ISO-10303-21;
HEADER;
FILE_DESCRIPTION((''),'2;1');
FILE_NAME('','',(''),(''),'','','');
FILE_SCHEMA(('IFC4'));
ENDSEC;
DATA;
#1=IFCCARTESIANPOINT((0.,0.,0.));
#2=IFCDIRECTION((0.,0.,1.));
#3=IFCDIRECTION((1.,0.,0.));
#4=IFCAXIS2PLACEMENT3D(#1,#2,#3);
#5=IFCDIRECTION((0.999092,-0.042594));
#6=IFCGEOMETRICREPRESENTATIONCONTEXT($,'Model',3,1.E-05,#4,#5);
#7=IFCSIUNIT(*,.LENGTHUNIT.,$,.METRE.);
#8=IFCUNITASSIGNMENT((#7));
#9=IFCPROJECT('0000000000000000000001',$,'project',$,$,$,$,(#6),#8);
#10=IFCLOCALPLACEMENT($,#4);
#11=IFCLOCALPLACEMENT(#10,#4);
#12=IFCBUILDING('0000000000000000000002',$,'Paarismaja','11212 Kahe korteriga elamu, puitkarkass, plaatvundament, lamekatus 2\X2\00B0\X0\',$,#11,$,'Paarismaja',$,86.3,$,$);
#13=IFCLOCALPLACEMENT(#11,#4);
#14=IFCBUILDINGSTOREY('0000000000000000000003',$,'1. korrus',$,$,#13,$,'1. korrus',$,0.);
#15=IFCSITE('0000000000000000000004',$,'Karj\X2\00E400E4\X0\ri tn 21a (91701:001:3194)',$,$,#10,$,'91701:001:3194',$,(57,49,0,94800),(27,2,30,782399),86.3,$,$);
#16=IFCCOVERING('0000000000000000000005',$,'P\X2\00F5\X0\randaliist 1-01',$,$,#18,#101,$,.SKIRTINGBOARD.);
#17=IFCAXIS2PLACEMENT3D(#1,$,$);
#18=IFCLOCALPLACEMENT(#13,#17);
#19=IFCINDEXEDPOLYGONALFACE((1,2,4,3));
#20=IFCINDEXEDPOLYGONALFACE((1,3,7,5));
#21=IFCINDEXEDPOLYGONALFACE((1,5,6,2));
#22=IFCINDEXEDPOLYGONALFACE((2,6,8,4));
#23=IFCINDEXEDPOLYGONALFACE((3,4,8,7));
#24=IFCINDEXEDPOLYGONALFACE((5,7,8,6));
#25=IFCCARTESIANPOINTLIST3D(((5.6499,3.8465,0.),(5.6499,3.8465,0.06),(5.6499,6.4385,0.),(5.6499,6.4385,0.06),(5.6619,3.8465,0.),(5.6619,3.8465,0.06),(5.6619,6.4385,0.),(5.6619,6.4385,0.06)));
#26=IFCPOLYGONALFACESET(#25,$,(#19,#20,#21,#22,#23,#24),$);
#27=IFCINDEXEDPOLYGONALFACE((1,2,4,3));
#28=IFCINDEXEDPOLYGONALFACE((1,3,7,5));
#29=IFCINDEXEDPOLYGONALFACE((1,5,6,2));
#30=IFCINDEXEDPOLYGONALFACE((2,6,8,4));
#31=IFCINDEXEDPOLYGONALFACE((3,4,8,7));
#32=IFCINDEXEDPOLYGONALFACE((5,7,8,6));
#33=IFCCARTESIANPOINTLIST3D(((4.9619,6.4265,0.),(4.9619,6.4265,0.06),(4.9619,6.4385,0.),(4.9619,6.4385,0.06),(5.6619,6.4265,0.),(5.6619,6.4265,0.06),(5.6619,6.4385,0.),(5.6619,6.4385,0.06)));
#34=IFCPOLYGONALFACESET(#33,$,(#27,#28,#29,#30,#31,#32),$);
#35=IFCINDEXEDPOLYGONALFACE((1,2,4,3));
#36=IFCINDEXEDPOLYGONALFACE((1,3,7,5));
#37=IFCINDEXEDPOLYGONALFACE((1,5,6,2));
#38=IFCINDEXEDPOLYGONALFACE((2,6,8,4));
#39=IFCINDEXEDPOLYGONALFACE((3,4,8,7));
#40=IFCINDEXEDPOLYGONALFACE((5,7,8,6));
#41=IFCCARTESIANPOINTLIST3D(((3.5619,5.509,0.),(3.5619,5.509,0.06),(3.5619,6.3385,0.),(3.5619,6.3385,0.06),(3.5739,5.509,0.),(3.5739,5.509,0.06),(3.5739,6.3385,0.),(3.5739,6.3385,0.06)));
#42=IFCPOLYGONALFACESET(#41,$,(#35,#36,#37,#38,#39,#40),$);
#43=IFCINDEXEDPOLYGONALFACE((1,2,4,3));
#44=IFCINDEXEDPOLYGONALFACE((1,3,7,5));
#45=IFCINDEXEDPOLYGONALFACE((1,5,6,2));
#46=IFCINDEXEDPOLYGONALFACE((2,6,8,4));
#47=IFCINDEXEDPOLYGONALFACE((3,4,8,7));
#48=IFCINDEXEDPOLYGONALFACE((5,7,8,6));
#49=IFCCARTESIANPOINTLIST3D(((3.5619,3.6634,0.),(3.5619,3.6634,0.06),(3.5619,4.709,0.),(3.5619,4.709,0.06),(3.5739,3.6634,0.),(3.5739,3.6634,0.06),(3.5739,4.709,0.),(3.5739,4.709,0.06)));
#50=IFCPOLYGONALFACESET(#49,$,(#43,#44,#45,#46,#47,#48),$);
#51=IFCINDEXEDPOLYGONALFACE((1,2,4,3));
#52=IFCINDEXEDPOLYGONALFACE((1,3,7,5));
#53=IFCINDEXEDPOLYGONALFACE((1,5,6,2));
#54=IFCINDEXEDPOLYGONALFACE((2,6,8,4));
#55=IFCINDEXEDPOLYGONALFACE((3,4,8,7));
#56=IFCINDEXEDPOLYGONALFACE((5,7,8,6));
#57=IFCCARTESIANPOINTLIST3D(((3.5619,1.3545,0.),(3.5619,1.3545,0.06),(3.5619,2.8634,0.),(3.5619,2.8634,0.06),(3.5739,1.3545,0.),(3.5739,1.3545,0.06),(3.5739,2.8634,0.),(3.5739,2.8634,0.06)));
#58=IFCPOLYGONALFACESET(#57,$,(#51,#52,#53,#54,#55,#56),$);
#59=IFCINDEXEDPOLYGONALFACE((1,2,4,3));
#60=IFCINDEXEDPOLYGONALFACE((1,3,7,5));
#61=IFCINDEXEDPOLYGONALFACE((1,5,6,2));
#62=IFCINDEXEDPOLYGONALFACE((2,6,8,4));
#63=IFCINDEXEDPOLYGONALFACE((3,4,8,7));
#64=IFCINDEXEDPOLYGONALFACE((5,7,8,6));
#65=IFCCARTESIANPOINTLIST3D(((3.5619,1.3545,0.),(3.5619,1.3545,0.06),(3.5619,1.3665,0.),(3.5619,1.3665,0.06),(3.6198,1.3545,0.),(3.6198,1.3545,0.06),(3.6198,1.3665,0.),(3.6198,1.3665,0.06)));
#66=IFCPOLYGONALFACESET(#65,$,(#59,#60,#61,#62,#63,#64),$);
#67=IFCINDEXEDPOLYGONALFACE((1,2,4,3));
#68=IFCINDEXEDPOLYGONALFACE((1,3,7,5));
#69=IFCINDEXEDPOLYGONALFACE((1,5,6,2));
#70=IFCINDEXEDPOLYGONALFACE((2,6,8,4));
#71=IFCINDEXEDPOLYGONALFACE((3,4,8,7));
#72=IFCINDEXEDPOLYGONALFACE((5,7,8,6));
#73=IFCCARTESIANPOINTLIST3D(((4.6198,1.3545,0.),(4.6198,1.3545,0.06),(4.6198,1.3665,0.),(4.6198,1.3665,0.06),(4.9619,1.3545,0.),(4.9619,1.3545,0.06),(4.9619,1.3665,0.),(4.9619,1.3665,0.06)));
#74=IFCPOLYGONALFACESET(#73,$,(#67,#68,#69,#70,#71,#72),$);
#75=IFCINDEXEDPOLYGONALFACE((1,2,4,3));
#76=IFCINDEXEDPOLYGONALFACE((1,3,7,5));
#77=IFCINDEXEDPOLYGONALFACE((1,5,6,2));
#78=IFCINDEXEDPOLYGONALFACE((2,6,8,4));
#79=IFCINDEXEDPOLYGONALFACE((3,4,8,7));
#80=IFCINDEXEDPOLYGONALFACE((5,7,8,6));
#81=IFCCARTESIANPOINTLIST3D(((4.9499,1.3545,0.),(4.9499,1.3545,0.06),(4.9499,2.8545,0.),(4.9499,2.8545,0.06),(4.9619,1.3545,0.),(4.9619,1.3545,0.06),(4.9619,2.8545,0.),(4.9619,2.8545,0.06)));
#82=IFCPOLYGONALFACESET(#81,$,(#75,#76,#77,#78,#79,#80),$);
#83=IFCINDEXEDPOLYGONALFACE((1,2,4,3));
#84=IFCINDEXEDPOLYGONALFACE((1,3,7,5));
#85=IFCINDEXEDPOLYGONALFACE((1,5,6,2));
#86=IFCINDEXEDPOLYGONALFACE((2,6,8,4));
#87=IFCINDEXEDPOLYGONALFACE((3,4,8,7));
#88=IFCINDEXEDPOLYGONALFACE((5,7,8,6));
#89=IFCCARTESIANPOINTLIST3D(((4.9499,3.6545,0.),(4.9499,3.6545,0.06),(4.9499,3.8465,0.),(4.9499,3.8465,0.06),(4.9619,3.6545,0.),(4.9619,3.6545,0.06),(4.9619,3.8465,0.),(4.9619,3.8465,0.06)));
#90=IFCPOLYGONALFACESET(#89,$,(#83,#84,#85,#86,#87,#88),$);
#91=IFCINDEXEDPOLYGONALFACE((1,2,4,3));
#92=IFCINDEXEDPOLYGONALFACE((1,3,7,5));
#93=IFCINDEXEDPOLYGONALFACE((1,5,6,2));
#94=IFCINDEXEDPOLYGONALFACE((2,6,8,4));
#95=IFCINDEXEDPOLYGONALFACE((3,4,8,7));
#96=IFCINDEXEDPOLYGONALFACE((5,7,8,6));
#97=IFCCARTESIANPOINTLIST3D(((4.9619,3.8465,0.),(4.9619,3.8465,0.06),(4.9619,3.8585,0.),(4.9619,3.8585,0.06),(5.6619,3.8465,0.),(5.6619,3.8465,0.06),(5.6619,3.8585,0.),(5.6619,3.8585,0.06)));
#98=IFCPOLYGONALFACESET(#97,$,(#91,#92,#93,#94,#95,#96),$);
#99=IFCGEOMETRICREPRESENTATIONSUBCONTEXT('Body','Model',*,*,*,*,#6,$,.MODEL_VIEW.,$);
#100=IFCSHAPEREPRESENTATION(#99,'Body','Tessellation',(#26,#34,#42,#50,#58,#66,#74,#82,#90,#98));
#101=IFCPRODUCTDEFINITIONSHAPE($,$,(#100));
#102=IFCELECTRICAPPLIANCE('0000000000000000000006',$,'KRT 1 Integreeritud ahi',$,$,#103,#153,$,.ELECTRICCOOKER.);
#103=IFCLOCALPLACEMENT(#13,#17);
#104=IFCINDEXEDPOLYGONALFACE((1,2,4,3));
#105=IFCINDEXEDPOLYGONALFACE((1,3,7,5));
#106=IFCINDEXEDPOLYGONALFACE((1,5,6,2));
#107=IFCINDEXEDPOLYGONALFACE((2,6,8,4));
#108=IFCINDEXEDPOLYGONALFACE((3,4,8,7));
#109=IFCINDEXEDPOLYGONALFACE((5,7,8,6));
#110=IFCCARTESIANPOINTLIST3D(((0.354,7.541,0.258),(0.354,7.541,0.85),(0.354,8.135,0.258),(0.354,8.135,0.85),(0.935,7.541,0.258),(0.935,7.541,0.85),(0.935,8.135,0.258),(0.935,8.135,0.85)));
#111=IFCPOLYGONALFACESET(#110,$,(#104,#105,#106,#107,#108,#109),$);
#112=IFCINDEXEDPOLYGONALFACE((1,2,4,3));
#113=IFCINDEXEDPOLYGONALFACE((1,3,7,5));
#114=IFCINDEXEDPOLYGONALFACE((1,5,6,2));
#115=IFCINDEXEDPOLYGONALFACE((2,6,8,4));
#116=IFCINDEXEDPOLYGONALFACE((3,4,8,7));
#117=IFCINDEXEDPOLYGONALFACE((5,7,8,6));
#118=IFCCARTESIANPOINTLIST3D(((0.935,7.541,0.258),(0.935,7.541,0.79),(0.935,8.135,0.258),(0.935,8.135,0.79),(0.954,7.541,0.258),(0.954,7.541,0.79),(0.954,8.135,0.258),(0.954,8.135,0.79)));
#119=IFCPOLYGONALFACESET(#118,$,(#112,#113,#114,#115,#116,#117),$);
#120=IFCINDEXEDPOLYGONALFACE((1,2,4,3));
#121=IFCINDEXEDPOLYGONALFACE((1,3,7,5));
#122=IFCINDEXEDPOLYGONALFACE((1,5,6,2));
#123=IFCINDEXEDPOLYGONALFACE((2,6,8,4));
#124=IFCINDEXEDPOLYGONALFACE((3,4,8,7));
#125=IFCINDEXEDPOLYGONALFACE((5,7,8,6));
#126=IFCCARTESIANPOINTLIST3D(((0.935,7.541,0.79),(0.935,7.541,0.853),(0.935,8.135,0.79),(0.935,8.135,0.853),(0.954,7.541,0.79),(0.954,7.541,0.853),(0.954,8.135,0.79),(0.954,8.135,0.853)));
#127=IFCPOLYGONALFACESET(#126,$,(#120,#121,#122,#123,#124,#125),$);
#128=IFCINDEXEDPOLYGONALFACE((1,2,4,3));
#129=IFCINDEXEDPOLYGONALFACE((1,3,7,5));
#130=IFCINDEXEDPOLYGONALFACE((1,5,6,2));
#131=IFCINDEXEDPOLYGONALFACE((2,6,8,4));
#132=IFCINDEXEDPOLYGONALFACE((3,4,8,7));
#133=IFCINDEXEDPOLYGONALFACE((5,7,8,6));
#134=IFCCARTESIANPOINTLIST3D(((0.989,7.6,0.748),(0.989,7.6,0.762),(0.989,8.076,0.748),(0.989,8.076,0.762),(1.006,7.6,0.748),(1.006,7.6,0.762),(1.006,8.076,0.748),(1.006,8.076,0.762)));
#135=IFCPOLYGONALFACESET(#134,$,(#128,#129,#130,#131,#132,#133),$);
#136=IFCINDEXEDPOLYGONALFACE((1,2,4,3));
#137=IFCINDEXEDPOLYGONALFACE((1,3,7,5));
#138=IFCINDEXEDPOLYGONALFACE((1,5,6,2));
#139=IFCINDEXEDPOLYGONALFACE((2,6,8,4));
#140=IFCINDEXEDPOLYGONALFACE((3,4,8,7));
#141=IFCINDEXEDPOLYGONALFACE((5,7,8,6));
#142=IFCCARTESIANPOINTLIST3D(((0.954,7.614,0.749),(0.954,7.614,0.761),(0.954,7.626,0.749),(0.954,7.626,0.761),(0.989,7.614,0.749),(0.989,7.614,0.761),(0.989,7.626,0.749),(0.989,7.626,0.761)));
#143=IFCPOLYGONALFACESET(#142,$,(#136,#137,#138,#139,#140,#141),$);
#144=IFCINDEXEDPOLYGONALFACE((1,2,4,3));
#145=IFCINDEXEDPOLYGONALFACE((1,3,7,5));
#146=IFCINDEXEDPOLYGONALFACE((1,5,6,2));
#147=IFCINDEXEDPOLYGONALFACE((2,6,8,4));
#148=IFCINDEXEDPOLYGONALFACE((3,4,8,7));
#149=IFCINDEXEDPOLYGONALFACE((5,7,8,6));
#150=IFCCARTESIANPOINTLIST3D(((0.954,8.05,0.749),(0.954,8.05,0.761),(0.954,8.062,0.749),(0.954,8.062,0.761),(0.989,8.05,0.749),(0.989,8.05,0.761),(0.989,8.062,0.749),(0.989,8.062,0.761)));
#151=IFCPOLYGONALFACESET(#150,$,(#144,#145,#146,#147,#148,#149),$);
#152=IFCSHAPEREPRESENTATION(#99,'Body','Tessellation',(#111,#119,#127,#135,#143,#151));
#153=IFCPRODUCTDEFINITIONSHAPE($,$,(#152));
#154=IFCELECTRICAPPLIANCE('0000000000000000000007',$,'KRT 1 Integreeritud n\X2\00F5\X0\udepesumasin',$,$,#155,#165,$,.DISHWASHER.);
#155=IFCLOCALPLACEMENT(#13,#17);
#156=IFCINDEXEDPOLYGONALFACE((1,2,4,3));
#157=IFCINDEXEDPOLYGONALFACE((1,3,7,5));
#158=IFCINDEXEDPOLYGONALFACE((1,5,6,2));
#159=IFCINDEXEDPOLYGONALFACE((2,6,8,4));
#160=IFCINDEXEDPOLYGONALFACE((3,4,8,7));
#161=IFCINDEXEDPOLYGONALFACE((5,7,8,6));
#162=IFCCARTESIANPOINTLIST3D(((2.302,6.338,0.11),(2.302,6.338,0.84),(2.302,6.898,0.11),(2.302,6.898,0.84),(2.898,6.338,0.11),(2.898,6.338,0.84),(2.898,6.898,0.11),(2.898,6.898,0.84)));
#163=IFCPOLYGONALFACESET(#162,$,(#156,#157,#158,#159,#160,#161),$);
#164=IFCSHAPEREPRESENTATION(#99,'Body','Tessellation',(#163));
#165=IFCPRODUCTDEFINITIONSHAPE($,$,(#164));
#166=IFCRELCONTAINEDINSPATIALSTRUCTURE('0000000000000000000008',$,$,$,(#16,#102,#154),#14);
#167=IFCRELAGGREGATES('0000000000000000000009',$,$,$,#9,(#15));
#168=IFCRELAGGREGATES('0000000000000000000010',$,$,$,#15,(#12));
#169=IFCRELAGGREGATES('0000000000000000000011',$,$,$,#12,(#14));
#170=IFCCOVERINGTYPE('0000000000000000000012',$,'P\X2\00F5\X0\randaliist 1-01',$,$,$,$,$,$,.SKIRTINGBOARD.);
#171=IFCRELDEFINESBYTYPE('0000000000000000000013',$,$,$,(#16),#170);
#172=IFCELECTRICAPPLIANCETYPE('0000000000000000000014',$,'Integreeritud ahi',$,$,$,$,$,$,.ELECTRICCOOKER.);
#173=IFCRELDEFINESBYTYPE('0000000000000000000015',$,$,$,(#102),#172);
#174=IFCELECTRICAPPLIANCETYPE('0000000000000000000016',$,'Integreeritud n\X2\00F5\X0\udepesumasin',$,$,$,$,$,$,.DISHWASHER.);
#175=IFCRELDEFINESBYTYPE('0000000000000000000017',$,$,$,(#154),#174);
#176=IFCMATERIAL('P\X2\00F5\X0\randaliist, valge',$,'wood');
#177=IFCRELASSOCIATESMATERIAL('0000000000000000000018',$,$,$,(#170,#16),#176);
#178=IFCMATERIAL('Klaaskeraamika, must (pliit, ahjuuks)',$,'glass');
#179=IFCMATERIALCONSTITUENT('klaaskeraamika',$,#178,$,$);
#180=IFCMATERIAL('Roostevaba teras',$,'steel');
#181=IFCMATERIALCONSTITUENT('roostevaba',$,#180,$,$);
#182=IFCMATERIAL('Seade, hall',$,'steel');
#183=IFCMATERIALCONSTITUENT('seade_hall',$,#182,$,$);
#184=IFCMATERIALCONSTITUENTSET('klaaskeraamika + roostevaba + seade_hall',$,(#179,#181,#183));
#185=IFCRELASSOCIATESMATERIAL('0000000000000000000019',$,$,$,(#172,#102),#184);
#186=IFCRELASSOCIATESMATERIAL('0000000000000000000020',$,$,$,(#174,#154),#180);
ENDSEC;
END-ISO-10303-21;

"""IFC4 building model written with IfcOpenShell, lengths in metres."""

from ifc_helpers import new_model, si_unit, direction, frame, origin_with_axes, place, context, subcontext, project, spatial, indexed_curve, outline, extrude, material, constituent, constituent_set, type_object, element, save


model = new_model("IFC4")

# Units and contexts
model_context = context("Model", 3, precision=1e-05, world=origin_with_axes(), true_north=direction((0.999092, -0.042594)))
body_context = subcontext(model_context, "Body", "Model", "MODEL_VIEW")
ifc_project = project(units=[si_unit("LENGTHUNIT", "METRE")], contexts=[model_context])

# Site, building, storey
site_placement = place(None, origin_with_axes())
site = spatial("IfcSite", under=ifc_project, at=site_placement, Name="Karjääri tn 21a (91701:001:3194)", LongName="91701:001:3194", RefLatitude=(57, 49, 0, 94800), RefLongitude=(27, 2, 30, 782399), RefElevation=86.3)
building_placement = place(site_placement, origin_with_axes())
building = spatial("IfcBuilding", under=site, at=building_placement, Name="Paarismaja", Description="11212 Kahe korteriga elamu, puitkarkass, plaatvundament, lamekatus 2°", LongName="Paarismaja", ElevationOfRefHeight=86.3)
storey_placement = place(building_placement, origin_with_axes())
storey = spatial("IfcBuildingStorey", under=building, at=storey_placement, Name="1. korrus", LongName="1. korrus", Elevation=0.0)

# Covering
ifc_material_1 = material(Name="Põrandaliist, valge", Category="wood")
covering_type_1 = type_object("IfcCoveringType", Name="Põrandaliist 1-01", PredefinedType="SKIRTINGBOARD", material=ifc_material_1)
covering_1_placement = place(storey_placement, origin_with_axes())
element("IfcCovering", 1, at=covering_1_placement, inside=storey, type_object=covering_type_1, material=ifc_material_1, Name="Põrandaliist 1-01", PredefinedType="SKIRTINGBOARD", context=body_context, shape_type="SweptSolid", body=[
    extrude(outline(indexed_curve([(5.6499, 3.8465), (5.6499, 6.4385), (5.6619, 6.4385), (5.6619, 3.8465), (5.6499, 3.8465)], self_intersect=False)), origin_with_axes(), (0.0, 0.0, 1.0), 0.06),
    extrude(outline(indexed_curve([(5.6619, 6.4265), (4.9619, 6.4265), (4.9619, 6.4385), (5.6619, 6.4385), (5.6619, 6.4265)], self_intersect=False)), origin_with_axes(), (0.0, 0.0, 1.0), 0.06),
    extrude(outline(indexed_curve([(3.5619, 6.3385), (3.5739, 6.3385), (3.5739, 5.509), (3.5619, 5.509), (3.5619, 6.3385)], self_intersect=False)), origin_with_axes(), (0.0, 0.0, 1.0), 0.06),
    extrude(outline(indexed_curve([(3.5619, 4.709), (3.5739, 4.709), (3.5739, 3.6634), (3.5619, 3.6634), (3.5619, 4.709)], self_intersect=False)), origin_with_axes(), (0.0, 0.0, 1.0), 0.06),
    extrude(outline(indexed_curve([(3.5739, 1.3545), (3.5619, 1.3545), (3.5619, 2.8634), (3.5739, 2.8634), (3.5739, 1.3545)], self_intersect=False)), origin_with_axes(), (0.0, 0.0, 1.0), 0.06),
    extrude(outline(indexed_curve([(3.5619, 1.3545), (3.5619, 1.3665), (3.6198, 1.3665), (3.6198, 1.3545), (3.5619, 1.3545)], self_intersect=False)), origin_with_axes(), (0.0, 0.0, 1.0), 0.06),
    extrude(outline(indexed_curve([(4.9619, 1.3665), (4.9619, 1.3545), (4.6198, 1.3545), (4.6198, 1.3665), (4.9619, 1.3665)], self_intersect=False)), origin_with_axes(), (0.0, 0.0, 1.0), 0.06),
    extrude(outline(indexed_curve([(4.9619, 1.3545), (4.9499, 1.3545), (4.9499, 2.8545), (4.9619, 2.8545), (4.9619, 1.3545)], self_intersect=False)), origin_with_axes(), (0.0, 0.0, 1.0), 0.06),
    extrude(outline(indexed_curve([(4.9499, 3.8465), (4.9619, 3.8465), (4.9619, 3.6545), (4.9499, 3.6545), (4.9499, 3.8465)], self_intersect=False)), origin_with_axes(), (0.0, 0.0, 1.0), 0.06),
    extrude(outline(indexed_curve([(4.9619, 3.8585), (5.6619, 3.8585), (5.6619, 3.8465), (4.9619, 3.8465), (4.9619, 3.8585)], self_intersect=False)), origin_with_axes(), (0.0, 0.0, 1.0), 0.06),
])

# Electric appliances
ifc_material_2 = material(Name="Klaaskeraamika, must (pliit, ahjuuks)", Category="glass")
ifc_constituent_1 = constituent(ifc_material_2, Name="klaaskeraamika")
ifc_material_3 = material(Name="Roostevaba teras", Category="steel")
ifc_constituent_2 = constituent(ifc_material_3, Name="roostevaba")
ifc_material_4 = material(Name="Seade, hall", Category="steel")
ifc_constituent_3 = constituent(ifc_material_4, Name="seade_hall")
ifc_constituent_set_1 = constituent_set(constituents=[ifc_constituent_1, ifc_constituent_2, ifc_constituent_3], Name="klaaskeraamika + roostevaba + seade_hall")
electric_appliance_type_1 = type_object("IfcElectricApplianceType", Name="Integreeritud ahi", PredefinedType="ELECTRICCOOKER", material=ifc_constituent_set_1)
electric_appliance_1_placement = place(storey_placement, origin_with_axes())
element("IfcElectricAppliance", 2, at=electric_appliance_1_placement, inside=storey, type_object=electric_appliance_type_1, material=ifc_constituent_set_1, Name="KRT 1 Integreeritud ahi", PredefinedType="ELECTRICCOOKER", context=body_context, shape_type="SweptSolid", body=[
    extrude(outline(indexed_curve([(0.354, 7.541), (0.935, 7.541), (0.935, 8.135), (0.354, 8.135), (0.354, 7.541)], self_intersect=False)), frame((0.0, 0.0, 0.258), z_axis=(0.0, 0.0, 1.0), x_axis=(1.0, 0.0, 0.0)), (0.0, 0.0, 1.0), 0.592),
    extrude(outline(indexed_curve([(0.935, 7.541), (0.954, 7.541), (0.954, 8.135), (0.935, 8.135), (0.935, 7.541)], self_intersect=False)), frame((0.0, 0.0, 0.258), z_axis=(0.0, 0.0, 1.0), x_axis=(1.0, 0.0, 0.0)), (0.0, 0.0, 1.0), 0.532),
    extrude(outline(indexed_curve([(0.935, 7.541), (0.954, 7.541), (0.954, 8.135), (0.935, 8.135), (0.935, 7.541)], self_intersect=False)), frame((0.0, 0.0, 0.79), z_axis=(0.0, 0.0, 1.0), x_axis=(1.0, 0.0, 0.0)), (0.0, 0.0, 1.0), 0.063),
    extrude(outline(indexed_curve([(0.989, 7.6), (1.006, 7.6), (1.006, 8.076), (0.989, 8.076), (0.989, 7.6)], self_intersect=False)), frame((0.0, 0.0, 0.748), z_axis=(0.0, 0.0, 1.0), x_axis=(1.0, 0.0, 0.0)), (0.0, 0.0, 1.0), 0.014),
    extrude(outline(indexed_curve([(0.954, 7.614), (0.989, 7.614), (0.989, 7.626), (0.954, 7.626), (0.954, 7.614)], self_intersect=False)), frame((0.0, 0.0, 0.749), z_axis=(0.0, 0.0, 1.0), x_axis=(1.0, 0.0, 0.0)), (0.0, 0.0, 1.0), 0.012),
    extrude(outline(indexed_curve([(0.954, 8.05), (0.989, 8.05), (0.989, 8.062), (0.954, 8.062), (0.954, 8.05)], self_intersect=False)), frame((0.0, 0.0, 0.749), z_axis=(0.0, 0.0, 1.0), x_axis=(1.0, 0.0, 0.0)), (0.0, 0.0, 1.0), 0.012),
])
electric_appliance_type_2 = type_object("IfcElectricApplianceType", Name="Integreeritud nõudepesumasin", PredefinedType="DISHWASHER", material=ifc_material_3)
electric_appliance_2_placement = place(storey_placement, origin_with_axes())
element("IfcElectricAppliance", 3, at=electric_appliance_2_placement, inside=storey, type_object=electric_appliance_type_2, material=ifc_material_3, Name="KRT 1 Integreeritud nõudepesumasin", PredefinedType="DISHWASHER", context=body_context, shape_type="SweptSolid", body=[
    extrude(outline(indexed_curve([(2.302, 6.338), (2.898, 6.338), (2.898, 6.898), (2.302, 6.898), (2.302, 6.338)], self_intersect=False)), frame((0.0, 0.0, 0.11), z_axis=(0.0, 0.0, 1.0), x_axis=(1.0, 0.0, 0.0)), (0.0, 0.0, 1.0), 0.73),
])

save(model, "model.ifc")
